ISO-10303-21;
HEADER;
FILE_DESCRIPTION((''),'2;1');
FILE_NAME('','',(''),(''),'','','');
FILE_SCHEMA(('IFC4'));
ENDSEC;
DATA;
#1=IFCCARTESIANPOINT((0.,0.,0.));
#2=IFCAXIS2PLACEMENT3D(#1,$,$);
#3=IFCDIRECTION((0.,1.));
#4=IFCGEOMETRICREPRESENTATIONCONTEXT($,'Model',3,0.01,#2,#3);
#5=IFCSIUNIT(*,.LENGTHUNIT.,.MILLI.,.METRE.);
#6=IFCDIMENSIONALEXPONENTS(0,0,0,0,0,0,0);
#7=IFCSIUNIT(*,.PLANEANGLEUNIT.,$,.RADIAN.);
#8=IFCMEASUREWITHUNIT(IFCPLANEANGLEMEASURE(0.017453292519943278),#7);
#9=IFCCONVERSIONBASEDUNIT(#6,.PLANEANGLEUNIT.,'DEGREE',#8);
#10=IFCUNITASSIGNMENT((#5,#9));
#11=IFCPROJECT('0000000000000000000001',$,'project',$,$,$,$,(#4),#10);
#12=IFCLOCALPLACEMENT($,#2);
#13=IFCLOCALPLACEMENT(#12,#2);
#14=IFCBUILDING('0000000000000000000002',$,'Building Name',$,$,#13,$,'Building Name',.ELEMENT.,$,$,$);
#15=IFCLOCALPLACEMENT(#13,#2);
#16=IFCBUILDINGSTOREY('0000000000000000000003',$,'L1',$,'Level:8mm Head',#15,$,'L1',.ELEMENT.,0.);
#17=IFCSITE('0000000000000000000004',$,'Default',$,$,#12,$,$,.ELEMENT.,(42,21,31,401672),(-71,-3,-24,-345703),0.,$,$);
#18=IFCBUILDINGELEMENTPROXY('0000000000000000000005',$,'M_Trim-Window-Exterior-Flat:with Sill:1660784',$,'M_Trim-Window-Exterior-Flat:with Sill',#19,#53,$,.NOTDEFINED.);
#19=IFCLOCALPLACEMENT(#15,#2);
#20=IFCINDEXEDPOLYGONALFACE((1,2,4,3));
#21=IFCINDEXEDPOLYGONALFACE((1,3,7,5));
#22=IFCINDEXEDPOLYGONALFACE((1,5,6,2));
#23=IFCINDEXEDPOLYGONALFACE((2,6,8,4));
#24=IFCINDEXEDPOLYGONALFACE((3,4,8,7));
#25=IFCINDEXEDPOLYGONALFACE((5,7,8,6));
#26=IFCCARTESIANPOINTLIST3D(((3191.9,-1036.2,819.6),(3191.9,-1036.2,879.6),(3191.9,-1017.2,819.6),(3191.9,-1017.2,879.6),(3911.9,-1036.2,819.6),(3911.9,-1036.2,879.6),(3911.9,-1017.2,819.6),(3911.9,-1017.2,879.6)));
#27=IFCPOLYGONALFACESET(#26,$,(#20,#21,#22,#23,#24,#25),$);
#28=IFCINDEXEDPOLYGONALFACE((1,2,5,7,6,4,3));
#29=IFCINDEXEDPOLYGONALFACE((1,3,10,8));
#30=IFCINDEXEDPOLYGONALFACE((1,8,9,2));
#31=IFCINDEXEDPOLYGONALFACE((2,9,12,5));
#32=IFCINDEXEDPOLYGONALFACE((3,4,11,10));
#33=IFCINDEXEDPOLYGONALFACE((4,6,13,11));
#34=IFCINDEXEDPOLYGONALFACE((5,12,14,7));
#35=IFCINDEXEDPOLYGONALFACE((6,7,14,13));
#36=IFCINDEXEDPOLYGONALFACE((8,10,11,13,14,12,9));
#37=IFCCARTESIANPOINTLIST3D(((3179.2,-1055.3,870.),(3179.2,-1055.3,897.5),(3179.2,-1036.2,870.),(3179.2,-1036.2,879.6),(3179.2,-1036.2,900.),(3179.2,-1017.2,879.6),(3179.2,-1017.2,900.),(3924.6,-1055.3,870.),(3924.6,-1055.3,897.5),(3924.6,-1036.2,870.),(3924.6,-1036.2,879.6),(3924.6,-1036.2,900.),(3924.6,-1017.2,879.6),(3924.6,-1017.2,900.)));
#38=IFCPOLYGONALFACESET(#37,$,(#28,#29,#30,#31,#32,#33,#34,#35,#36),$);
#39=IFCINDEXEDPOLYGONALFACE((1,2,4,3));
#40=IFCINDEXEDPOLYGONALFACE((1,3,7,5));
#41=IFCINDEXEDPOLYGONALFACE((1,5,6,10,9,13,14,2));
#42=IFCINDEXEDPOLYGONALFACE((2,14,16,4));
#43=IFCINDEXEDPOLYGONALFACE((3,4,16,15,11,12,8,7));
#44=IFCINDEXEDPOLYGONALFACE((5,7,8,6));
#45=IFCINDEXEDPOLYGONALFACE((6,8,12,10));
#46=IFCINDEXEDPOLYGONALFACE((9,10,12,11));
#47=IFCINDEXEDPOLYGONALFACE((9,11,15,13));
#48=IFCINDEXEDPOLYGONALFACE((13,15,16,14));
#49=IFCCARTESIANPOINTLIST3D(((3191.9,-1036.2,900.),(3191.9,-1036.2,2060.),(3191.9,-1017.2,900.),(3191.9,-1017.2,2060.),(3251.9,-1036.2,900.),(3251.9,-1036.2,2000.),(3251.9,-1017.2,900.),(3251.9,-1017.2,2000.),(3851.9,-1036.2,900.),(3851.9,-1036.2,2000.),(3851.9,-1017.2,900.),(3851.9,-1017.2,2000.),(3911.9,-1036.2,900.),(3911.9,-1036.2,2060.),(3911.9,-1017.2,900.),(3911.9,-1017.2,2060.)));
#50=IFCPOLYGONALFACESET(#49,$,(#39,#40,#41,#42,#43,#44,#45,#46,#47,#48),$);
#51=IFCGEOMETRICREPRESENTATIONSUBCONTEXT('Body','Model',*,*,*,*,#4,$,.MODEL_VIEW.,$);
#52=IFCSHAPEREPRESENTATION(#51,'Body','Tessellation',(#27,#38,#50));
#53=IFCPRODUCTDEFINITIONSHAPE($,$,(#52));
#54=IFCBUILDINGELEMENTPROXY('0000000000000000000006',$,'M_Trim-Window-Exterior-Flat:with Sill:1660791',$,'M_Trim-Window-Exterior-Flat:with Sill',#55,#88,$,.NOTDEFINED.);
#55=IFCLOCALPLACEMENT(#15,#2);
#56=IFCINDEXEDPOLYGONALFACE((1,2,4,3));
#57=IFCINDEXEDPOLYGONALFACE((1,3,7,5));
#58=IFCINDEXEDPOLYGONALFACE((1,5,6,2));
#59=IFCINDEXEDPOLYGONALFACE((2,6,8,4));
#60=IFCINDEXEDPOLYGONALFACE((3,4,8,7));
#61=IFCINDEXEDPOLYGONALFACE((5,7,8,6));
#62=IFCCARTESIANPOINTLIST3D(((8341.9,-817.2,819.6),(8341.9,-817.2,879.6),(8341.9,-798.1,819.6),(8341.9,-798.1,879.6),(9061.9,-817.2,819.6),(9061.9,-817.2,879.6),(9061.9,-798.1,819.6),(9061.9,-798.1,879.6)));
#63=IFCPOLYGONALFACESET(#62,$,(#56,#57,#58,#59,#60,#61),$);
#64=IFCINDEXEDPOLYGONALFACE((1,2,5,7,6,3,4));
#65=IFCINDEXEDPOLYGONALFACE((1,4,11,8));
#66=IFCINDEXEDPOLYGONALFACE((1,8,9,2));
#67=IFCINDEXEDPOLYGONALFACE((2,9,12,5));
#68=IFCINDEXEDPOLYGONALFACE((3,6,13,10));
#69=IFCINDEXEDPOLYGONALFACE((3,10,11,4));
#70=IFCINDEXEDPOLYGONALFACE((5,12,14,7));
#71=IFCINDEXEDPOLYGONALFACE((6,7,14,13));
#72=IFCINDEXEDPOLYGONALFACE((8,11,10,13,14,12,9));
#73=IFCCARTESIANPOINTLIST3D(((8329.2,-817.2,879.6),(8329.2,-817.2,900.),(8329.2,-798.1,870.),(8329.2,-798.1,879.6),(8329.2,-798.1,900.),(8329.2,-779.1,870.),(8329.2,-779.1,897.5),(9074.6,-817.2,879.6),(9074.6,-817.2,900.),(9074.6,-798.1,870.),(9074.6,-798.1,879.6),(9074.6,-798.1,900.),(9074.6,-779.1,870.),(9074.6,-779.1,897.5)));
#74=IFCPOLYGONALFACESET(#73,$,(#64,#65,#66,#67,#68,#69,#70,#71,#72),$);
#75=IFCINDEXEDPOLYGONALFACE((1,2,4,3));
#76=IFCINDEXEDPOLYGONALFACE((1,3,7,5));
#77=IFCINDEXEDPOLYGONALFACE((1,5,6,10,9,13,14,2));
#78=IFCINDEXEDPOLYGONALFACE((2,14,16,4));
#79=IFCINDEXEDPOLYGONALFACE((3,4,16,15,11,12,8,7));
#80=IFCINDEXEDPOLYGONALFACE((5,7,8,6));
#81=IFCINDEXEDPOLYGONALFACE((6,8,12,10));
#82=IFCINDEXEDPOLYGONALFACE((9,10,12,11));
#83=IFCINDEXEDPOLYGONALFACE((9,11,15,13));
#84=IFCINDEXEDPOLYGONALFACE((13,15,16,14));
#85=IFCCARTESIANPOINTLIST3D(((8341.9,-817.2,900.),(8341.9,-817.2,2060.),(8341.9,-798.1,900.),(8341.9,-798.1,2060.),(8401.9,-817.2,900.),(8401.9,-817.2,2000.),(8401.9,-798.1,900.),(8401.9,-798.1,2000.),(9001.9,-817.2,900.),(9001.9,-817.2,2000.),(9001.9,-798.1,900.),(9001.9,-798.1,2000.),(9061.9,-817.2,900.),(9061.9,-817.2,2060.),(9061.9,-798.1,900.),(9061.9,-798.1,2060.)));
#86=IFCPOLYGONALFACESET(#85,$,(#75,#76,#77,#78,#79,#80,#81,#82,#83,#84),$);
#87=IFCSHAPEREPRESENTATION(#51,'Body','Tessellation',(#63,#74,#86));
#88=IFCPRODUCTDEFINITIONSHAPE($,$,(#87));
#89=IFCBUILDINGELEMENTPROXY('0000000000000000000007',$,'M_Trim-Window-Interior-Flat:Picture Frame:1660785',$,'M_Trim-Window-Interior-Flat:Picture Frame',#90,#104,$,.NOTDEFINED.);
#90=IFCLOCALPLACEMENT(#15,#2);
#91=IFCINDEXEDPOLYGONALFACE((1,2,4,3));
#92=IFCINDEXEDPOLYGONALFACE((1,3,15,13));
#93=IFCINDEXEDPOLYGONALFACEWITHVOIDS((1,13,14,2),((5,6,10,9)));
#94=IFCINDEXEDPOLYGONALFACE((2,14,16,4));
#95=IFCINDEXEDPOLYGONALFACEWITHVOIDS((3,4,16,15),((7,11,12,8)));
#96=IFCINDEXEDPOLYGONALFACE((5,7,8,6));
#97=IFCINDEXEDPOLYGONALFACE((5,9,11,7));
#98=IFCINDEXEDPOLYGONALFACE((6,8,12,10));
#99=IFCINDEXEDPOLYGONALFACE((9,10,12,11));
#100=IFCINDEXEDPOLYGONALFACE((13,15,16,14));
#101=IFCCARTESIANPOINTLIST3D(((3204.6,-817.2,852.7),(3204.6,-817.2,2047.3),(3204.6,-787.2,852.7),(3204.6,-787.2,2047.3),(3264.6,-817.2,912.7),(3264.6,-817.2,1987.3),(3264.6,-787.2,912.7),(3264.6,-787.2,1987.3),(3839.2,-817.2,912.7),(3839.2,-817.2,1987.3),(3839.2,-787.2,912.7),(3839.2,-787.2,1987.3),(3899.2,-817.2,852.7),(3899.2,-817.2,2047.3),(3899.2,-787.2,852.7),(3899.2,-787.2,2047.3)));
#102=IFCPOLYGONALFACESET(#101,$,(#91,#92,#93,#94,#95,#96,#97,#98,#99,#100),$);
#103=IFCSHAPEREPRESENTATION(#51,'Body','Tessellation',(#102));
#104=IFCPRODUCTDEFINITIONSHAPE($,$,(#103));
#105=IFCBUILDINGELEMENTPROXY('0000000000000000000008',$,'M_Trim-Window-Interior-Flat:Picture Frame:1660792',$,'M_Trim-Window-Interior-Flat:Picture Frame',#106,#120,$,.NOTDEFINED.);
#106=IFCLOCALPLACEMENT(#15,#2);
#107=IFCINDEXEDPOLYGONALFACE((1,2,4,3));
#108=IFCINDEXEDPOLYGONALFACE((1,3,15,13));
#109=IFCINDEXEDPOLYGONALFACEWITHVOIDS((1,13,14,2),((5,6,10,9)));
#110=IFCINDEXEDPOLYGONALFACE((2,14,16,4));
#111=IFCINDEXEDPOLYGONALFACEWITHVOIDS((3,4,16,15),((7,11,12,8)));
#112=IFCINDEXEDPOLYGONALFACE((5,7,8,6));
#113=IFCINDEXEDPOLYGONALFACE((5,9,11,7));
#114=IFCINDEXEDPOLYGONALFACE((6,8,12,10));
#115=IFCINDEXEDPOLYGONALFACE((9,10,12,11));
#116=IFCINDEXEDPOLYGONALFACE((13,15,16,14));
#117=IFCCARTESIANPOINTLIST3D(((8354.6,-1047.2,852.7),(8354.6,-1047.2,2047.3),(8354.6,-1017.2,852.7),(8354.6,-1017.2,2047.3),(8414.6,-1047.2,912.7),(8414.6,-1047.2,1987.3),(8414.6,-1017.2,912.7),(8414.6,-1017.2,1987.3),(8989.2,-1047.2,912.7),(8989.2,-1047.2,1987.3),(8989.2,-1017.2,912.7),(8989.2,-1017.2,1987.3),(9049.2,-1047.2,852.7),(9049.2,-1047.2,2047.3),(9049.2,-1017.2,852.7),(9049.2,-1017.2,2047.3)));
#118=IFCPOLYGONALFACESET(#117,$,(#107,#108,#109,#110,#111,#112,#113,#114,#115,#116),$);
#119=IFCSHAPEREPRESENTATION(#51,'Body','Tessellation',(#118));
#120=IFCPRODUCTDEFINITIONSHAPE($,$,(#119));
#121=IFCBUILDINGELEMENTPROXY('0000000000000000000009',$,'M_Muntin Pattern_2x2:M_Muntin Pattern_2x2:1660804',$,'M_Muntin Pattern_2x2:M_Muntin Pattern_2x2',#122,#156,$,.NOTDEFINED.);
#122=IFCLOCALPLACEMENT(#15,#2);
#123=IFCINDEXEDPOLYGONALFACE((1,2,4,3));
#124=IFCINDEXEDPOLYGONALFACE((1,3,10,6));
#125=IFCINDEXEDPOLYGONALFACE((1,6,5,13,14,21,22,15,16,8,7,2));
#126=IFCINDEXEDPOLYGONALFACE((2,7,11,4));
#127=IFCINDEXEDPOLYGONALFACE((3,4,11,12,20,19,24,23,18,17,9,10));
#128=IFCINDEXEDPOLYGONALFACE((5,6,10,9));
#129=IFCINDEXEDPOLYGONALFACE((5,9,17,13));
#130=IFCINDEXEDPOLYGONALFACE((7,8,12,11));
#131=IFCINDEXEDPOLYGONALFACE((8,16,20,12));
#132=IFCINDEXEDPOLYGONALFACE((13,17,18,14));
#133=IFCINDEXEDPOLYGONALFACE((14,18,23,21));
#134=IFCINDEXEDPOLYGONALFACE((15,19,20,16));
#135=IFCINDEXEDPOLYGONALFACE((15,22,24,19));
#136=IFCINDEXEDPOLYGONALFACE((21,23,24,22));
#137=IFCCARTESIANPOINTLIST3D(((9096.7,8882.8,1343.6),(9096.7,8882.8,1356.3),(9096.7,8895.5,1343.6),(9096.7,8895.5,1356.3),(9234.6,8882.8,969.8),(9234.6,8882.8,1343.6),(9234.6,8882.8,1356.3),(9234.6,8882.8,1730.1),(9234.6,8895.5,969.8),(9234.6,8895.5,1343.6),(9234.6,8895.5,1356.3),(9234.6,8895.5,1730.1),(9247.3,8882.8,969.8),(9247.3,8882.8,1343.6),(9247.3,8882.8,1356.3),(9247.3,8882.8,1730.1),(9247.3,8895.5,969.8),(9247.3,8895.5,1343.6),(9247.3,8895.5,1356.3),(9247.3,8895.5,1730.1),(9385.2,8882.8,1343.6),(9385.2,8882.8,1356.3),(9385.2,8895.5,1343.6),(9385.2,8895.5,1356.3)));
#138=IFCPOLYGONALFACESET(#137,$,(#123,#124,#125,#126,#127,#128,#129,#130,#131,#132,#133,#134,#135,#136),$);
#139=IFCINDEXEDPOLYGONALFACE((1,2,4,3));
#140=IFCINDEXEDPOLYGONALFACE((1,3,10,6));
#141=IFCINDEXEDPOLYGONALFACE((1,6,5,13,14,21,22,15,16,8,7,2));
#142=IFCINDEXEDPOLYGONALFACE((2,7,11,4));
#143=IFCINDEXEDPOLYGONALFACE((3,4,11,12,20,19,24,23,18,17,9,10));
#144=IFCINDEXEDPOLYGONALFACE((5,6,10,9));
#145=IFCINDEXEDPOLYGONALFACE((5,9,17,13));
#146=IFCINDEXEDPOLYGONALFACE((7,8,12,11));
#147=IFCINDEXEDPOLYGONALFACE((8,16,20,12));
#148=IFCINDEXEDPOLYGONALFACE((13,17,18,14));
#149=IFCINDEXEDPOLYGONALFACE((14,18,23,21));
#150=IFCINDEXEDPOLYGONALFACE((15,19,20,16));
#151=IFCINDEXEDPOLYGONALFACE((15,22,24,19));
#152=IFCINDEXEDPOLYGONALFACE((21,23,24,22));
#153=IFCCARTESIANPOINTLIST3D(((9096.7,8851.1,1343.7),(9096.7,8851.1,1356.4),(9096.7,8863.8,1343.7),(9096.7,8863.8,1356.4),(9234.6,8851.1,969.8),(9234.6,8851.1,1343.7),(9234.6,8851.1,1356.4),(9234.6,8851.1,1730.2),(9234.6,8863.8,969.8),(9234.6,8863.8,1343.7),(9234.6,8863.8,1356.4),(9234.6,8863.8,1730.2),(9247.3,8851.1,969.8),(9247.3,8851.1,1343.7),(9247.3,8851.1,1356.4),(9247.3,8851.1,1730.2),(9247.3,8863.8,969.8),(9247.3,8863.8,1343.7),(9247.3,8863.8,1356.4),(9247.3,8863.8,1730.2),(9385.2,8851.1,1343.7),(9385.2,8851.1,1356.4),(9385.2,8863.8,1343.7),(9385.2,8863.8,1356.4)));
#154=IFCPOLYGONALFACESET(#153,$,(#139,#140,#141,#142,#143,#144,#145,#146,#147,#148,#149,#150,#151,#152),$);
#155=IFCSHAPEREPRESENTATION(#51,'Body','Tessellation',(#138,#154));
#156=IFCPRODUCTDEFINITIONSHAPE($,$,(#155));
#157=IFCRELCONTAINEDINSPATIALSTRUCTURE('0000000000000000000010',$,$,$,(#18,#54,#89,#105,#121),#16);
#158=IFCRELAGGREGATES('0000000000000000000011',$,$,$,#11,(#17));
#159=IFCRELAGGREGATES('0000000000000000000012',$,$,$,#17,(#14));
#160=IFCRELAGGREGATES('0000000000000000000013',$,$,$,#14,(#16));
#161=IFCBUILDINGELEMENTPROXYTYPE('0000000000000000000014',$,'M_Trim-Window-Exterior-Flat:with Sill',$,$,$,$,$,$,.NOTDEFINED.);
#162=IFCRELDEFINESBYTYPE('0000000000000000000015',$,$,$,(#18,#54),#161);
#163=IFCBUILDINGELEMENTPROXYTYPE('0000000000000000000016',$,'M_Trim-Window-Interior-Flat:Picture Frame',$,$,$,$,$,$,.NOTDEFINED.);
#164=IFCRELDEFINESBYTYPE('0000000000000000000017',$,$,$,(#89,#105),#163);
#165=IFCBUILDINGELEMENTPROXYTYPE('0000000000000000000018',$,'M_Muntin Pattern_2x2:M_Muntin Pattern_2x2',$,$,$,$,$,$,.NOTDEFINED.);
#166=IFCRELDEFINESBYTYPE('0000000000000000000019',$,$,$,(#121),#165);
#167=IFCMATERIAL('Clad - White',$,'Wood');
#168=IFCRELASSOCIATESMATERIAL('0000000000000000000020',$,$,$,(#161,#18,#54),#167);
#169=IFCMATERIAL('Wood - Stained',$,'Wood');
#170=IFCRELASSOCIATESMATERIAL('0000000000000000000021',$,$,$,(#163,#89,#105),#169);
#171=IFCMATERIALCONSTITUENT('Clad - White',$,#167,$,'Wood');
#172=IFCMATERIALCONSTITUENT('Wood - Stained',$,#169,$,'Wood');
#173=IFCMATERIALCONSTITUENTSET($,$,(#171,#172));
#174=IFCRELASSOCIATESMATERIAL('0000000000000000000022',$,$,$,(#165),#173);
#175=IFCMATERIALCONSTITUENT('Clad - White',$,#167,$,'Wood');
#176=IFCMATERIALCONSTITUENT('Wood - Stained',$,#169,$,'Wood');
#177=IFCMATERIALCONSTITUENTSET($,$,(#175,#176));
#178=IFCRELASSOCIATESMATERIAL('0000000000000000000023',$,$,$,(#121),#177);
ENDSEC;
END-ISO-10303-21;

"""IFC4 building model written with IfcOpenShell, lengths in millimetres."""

from ifc_helpers import new_model, entity, si_unit, converted_unit, direction, frame, origin, place, context, subcontext, project, spatial, indexed_curve, outline, extrude, source, transform, mapped, material, constituent, constituent_set, type_object, type_shapes, element, save


model = new_model("IFC4")

# Units and contexts
model_context = context("Model", 3, precision=0.01, world=origin(), true_north=direction((0.0, 1.0)))
body_context = subcontext(model_context, "Body", "Model", "MODEL_VIEW")
ifc_project = project(units=[si_unit("LENGTHUNIT", "METRE", prefix="MILLI"), converted_unit("PLANEANGLEUNIT", "DEGREE", entity("IfcPlaneAngleMeasure", 0.017453292519943278), si_unit("PLANEANGLEUNIT", "RADIAN"), dimensions=[0, 0, 0, 0, 0, 0, 0])], contexts=[model_context])

# Site, building, storey
site_placement = place(None, origin())
site = spatial("IfcSite", under=ifc_project, at=site_placement, Name="Default", CompositionType="ELEMENT", RefLatitude=(42, 21, 31, 401672), RefLongitude=(-71, -3, -24, -345703), RefElevation=0.0)
building_placement = place(site_placement, origin())
building = spatial("IfcBuilding", under=site, at=building_placement, Name="Building Name", LongName="Building Name", CompositionType="ELEMENT")
storey_placement = place(building_placement, origin())
storey = spatial("IfcBuildingStorey", under=building, at=storey_placement, Name="L1", ObjectType="Level:8mm Head", LongName="L1", CompositionType="ELEMENT", Elevation=0.0)

# Building element proxies
ifc_material_1 = material(Name="Clad - White", Category="Wood")
ifc_material_2 = material(Name="Wood - Stained", Category="Wood")
building_element_proxy_type_1 = type_object("IfcBuildingElementProxyType", Name="M_Trim-Window-Exterior-Flat:with Sill", PredefinedType="NOTDEFINED", material=ifc_material_1)
shared_shape_1 = source(origin(), body_context, "Body", "SweptSolid", [
    extrude(outline(indexed_curve([(-360.0, -30.0), (360.0, -30.0), (360.0, 30.0), (-360.0, 30.0), (-360.0, -30.0)], self_intersect=False)), frame((0.0, -1150.4, 0.0), z_axis=(0.0, 0.0, 1.0), x_axis=(-1.0, 0.0, 0.0)), (0.0, 0.0, 1.0), 19.0),
    extrude(outline(indexed_curve([(-19.0, -15.2), (0.0, -15.2), (0.0, -5.7), (19.0, -5.7), (19.0, 14.8), (0.0, 14.8), (-19.0, 12.3), (-19.0, -15.2)], self_intersect=False)), frame((-372.7, -1114.8, 19.0), z_axis=(1.0, 0.0, 0.0), x_axis=(0.0, 0.0, -1.0)), (0.0, 0.0, 1.0), 745.4),
    extrude(outline(indexed_curve([(-595.0, -360.0), (565.0, -360.0), (565.0, -300.0), (-535.0, -300.0), (-535.0, 300.0), (565.0, 300.0), (565.0, 360.0), (-595.0, 360.0), (-595.0, -360.0)], self_intersect=False)), frame((0.0, -535.0, 0.0), z_axis=(0.0, 0.0, 1.0), x_axis=(0.0, -1.0, 0.0)), (0.0, 0.0, 1.0), 19.0),
])
type_shapes(building_element_proxy_type_1, [shared_shape_1])
for number, where, z_axis, x_axis, name in (
    (1, (3551.9, -1017.2, 2000.0), (0.0, -1.0, 0.0), (1.0, 0.0, 0.0), "M_Trim-Window-Exterior-Flat:with Sill:1660784"),
    (2, (8701.9, -817.2, 2000.0), (0.0, 1.0, 0.0), (-1.0, 0.0, 0.0), "M_Trim-Window-Exterior-Flat:with Sill:1660791"),
):
    element("IfcBuildingElementProxy", number, at=place(storey_placement, frame(where, z_axis=z_axis, x_axis=x_axis)), inside=storey, type_object=building_element_proxy_type_1, material=ifc_material_1, Name=name, ObjectType="M_Trim-Window-Exterior-Flat:with Sill", PredefinedType="NOTDEFINED", context=body_context, shape_type="MappedRepresentation", body=[
        mapped(shared_shape_1, transform((0.0, 0.0, 0.0), scale=1.0)),
    ])
building_element_proxy_type_2 = type_object("IfcBuildingElementProxyType", Name="M_Trim-Window-Interior-Flat:Picture Frame", PredefinedType="NOTDEFINED", material=ifc_material_2)
shared_shape_2 = source(origin(), body_context, "Body", "SweptSolid", [
    extrude(outline(indexed_curve([(-347.3, -597.3), (347.3, -597.3), (347.3, 597.3), (-347.3, 597.3), (-347.3, -597.3)], self_intersect=False), holes=[indexed_curve([(-287.3, -537.3), (-287.3, 537.3), (287.3, 537.3), (287.3, -537.3), (-287.3, -537.3)], self_intersect=False)]), frame((0.0, -550.0, 0.0), z_axis=(0.0, 0.0, 1.0), x_axis=(-1.0, 0.0, 0.0)), (0.0, 0.0, 1.0), 30.0),
])
type_shapes(building_element_proxy_type_2, [shared_shape_2])
for number, where, z_axis, x_axis, name in (
    (3, (3551.9, -817.2, 2000.0), (0.0, 1.0, 0.0), (-1.0, 0.0, 0.0), "M_Trim-Window-Interior-Flat:Picture Frame:1660785"),
    (4, (8701.9, -1017.2, 2000.0), (0.0, -1.0, 0.0), (1.0, 0.0, 0.0), "M_Trim-Window-Interior-Flat:Picture Frame:1660792"),
):
    element("IfcBuildingElementProxy", number, at=place(storey_placement, frame(where, z_axis=z_axis, x_axis=x_axis)), inside=storey, type_object=building_element_proxy_type_2, material=ifc_material_2, Name=name, ObjectType="M_Trim-Window-Interior-Flat:Picture Frame", PredefinedType="NOTDEFINED", context=body_context, shape_type="MappedRepresentation", body=[
        mapped(shared_shape_2, transform((0.0, 0.0, 0.0), scale=1.0)),
    ])
ifc_constituent_1 = constituent(ifc_material_1, Name="Clad - White", Category="Wood")
ifc_constituent_2 = constituent(ifc_material_2, Name="Wood - Stained", Category="Wood")
ifc_constituent_set_1 = constituent_set(constituents=[ifc_constituent_1, ifc_constituent_2])
ifc_constituent_3 = constituent(ifc_material_1, Name="Clad - White", Category="Wood")
ifc_constituent_4 = constituent(ifc_material_2, Name="Wood - Stained", Category="Wood")
ifc_constituent_set_2 = constituent_set(constituents=[ifc_constituent_3, ifc_constituent_4])
building_element_proxy_type_3 = type_object("IfcBuildingElementProxyType", Name="M_Muntin Pattern_2x2:M_Muntin Pattern_2x2", PredefinedType="NOTDEFINED", material=ifc_constituent_set_2)
shared_shape_3 = source(origin(), body_context, "Body", "SweptSolid", [
    extrude(outline(indexed_curve([(6.4, -6.4), (380.1, -6.4), (380.1, 6.3), (6.4, 6.3), (6.4, 144.2), (-6.3, 144.2), (-6.3, 6.3), (-380.2, 6.3), (-380.2, -6.4), (-6.3, -6.4), (-6.3, -144.2), (6.4, -144.2), (6.4, -6.4)], self_intersect=False)), frame((0.0, 9.5, 380.1), z_axis=(0.0, 1.0, 0.0), x_axis=(0.0, 0.0, 1.0)), (0.0, 0.0, 1.0), 12.7),
    extrude(outline(indexed_curve([(6.4, -6.4), (380.2, -6.4), (380.2, 6.3), (6.4, 6.3), (6.4, 144.2), (-6.3, 144.2), (-6.3, 6.3), (-380.2, 6.3), (-380.2, -6.4), (-6.3, -6.4), (-6.3, -144.2), (6.4, -144.2), (6.4, -6.4)], self_intersect=False)), frame((0.0, -22.2, 380.2), z_axis=(0.0, 1.0, 0.0), x_axis=(0.0, 0.0, 1.0)), (0.0, 0.0, 1.0), 12.7),
])
type_shapes(building_element_proxy_type_3, [shared_shape_3])
proxy_1_placement = place(storey_placement, frame((9241.0, 8873.3, 969.8)))
element("IfcBuildingElementProxy", 5, at=proxy_1_placement, inside=storey, type_object=building_element_proxy_type_3, material=ifc_constituent_set_1, Name="M_Muntin Pattern_2x2:M_Muntin Pattern_2x2:1660804", ObjectType="M_Muntin Pattern_2x2:M_Muntin Pattern_2x2", PredefinedType="NOTDEFINED", context=body_context, shape_type="MappedRepresentation", body=[
    mapped(shared_shape_3, transform((0.0, 0.0, 0.0), scale=1.0)),
])

save(model, "model.ifc")
